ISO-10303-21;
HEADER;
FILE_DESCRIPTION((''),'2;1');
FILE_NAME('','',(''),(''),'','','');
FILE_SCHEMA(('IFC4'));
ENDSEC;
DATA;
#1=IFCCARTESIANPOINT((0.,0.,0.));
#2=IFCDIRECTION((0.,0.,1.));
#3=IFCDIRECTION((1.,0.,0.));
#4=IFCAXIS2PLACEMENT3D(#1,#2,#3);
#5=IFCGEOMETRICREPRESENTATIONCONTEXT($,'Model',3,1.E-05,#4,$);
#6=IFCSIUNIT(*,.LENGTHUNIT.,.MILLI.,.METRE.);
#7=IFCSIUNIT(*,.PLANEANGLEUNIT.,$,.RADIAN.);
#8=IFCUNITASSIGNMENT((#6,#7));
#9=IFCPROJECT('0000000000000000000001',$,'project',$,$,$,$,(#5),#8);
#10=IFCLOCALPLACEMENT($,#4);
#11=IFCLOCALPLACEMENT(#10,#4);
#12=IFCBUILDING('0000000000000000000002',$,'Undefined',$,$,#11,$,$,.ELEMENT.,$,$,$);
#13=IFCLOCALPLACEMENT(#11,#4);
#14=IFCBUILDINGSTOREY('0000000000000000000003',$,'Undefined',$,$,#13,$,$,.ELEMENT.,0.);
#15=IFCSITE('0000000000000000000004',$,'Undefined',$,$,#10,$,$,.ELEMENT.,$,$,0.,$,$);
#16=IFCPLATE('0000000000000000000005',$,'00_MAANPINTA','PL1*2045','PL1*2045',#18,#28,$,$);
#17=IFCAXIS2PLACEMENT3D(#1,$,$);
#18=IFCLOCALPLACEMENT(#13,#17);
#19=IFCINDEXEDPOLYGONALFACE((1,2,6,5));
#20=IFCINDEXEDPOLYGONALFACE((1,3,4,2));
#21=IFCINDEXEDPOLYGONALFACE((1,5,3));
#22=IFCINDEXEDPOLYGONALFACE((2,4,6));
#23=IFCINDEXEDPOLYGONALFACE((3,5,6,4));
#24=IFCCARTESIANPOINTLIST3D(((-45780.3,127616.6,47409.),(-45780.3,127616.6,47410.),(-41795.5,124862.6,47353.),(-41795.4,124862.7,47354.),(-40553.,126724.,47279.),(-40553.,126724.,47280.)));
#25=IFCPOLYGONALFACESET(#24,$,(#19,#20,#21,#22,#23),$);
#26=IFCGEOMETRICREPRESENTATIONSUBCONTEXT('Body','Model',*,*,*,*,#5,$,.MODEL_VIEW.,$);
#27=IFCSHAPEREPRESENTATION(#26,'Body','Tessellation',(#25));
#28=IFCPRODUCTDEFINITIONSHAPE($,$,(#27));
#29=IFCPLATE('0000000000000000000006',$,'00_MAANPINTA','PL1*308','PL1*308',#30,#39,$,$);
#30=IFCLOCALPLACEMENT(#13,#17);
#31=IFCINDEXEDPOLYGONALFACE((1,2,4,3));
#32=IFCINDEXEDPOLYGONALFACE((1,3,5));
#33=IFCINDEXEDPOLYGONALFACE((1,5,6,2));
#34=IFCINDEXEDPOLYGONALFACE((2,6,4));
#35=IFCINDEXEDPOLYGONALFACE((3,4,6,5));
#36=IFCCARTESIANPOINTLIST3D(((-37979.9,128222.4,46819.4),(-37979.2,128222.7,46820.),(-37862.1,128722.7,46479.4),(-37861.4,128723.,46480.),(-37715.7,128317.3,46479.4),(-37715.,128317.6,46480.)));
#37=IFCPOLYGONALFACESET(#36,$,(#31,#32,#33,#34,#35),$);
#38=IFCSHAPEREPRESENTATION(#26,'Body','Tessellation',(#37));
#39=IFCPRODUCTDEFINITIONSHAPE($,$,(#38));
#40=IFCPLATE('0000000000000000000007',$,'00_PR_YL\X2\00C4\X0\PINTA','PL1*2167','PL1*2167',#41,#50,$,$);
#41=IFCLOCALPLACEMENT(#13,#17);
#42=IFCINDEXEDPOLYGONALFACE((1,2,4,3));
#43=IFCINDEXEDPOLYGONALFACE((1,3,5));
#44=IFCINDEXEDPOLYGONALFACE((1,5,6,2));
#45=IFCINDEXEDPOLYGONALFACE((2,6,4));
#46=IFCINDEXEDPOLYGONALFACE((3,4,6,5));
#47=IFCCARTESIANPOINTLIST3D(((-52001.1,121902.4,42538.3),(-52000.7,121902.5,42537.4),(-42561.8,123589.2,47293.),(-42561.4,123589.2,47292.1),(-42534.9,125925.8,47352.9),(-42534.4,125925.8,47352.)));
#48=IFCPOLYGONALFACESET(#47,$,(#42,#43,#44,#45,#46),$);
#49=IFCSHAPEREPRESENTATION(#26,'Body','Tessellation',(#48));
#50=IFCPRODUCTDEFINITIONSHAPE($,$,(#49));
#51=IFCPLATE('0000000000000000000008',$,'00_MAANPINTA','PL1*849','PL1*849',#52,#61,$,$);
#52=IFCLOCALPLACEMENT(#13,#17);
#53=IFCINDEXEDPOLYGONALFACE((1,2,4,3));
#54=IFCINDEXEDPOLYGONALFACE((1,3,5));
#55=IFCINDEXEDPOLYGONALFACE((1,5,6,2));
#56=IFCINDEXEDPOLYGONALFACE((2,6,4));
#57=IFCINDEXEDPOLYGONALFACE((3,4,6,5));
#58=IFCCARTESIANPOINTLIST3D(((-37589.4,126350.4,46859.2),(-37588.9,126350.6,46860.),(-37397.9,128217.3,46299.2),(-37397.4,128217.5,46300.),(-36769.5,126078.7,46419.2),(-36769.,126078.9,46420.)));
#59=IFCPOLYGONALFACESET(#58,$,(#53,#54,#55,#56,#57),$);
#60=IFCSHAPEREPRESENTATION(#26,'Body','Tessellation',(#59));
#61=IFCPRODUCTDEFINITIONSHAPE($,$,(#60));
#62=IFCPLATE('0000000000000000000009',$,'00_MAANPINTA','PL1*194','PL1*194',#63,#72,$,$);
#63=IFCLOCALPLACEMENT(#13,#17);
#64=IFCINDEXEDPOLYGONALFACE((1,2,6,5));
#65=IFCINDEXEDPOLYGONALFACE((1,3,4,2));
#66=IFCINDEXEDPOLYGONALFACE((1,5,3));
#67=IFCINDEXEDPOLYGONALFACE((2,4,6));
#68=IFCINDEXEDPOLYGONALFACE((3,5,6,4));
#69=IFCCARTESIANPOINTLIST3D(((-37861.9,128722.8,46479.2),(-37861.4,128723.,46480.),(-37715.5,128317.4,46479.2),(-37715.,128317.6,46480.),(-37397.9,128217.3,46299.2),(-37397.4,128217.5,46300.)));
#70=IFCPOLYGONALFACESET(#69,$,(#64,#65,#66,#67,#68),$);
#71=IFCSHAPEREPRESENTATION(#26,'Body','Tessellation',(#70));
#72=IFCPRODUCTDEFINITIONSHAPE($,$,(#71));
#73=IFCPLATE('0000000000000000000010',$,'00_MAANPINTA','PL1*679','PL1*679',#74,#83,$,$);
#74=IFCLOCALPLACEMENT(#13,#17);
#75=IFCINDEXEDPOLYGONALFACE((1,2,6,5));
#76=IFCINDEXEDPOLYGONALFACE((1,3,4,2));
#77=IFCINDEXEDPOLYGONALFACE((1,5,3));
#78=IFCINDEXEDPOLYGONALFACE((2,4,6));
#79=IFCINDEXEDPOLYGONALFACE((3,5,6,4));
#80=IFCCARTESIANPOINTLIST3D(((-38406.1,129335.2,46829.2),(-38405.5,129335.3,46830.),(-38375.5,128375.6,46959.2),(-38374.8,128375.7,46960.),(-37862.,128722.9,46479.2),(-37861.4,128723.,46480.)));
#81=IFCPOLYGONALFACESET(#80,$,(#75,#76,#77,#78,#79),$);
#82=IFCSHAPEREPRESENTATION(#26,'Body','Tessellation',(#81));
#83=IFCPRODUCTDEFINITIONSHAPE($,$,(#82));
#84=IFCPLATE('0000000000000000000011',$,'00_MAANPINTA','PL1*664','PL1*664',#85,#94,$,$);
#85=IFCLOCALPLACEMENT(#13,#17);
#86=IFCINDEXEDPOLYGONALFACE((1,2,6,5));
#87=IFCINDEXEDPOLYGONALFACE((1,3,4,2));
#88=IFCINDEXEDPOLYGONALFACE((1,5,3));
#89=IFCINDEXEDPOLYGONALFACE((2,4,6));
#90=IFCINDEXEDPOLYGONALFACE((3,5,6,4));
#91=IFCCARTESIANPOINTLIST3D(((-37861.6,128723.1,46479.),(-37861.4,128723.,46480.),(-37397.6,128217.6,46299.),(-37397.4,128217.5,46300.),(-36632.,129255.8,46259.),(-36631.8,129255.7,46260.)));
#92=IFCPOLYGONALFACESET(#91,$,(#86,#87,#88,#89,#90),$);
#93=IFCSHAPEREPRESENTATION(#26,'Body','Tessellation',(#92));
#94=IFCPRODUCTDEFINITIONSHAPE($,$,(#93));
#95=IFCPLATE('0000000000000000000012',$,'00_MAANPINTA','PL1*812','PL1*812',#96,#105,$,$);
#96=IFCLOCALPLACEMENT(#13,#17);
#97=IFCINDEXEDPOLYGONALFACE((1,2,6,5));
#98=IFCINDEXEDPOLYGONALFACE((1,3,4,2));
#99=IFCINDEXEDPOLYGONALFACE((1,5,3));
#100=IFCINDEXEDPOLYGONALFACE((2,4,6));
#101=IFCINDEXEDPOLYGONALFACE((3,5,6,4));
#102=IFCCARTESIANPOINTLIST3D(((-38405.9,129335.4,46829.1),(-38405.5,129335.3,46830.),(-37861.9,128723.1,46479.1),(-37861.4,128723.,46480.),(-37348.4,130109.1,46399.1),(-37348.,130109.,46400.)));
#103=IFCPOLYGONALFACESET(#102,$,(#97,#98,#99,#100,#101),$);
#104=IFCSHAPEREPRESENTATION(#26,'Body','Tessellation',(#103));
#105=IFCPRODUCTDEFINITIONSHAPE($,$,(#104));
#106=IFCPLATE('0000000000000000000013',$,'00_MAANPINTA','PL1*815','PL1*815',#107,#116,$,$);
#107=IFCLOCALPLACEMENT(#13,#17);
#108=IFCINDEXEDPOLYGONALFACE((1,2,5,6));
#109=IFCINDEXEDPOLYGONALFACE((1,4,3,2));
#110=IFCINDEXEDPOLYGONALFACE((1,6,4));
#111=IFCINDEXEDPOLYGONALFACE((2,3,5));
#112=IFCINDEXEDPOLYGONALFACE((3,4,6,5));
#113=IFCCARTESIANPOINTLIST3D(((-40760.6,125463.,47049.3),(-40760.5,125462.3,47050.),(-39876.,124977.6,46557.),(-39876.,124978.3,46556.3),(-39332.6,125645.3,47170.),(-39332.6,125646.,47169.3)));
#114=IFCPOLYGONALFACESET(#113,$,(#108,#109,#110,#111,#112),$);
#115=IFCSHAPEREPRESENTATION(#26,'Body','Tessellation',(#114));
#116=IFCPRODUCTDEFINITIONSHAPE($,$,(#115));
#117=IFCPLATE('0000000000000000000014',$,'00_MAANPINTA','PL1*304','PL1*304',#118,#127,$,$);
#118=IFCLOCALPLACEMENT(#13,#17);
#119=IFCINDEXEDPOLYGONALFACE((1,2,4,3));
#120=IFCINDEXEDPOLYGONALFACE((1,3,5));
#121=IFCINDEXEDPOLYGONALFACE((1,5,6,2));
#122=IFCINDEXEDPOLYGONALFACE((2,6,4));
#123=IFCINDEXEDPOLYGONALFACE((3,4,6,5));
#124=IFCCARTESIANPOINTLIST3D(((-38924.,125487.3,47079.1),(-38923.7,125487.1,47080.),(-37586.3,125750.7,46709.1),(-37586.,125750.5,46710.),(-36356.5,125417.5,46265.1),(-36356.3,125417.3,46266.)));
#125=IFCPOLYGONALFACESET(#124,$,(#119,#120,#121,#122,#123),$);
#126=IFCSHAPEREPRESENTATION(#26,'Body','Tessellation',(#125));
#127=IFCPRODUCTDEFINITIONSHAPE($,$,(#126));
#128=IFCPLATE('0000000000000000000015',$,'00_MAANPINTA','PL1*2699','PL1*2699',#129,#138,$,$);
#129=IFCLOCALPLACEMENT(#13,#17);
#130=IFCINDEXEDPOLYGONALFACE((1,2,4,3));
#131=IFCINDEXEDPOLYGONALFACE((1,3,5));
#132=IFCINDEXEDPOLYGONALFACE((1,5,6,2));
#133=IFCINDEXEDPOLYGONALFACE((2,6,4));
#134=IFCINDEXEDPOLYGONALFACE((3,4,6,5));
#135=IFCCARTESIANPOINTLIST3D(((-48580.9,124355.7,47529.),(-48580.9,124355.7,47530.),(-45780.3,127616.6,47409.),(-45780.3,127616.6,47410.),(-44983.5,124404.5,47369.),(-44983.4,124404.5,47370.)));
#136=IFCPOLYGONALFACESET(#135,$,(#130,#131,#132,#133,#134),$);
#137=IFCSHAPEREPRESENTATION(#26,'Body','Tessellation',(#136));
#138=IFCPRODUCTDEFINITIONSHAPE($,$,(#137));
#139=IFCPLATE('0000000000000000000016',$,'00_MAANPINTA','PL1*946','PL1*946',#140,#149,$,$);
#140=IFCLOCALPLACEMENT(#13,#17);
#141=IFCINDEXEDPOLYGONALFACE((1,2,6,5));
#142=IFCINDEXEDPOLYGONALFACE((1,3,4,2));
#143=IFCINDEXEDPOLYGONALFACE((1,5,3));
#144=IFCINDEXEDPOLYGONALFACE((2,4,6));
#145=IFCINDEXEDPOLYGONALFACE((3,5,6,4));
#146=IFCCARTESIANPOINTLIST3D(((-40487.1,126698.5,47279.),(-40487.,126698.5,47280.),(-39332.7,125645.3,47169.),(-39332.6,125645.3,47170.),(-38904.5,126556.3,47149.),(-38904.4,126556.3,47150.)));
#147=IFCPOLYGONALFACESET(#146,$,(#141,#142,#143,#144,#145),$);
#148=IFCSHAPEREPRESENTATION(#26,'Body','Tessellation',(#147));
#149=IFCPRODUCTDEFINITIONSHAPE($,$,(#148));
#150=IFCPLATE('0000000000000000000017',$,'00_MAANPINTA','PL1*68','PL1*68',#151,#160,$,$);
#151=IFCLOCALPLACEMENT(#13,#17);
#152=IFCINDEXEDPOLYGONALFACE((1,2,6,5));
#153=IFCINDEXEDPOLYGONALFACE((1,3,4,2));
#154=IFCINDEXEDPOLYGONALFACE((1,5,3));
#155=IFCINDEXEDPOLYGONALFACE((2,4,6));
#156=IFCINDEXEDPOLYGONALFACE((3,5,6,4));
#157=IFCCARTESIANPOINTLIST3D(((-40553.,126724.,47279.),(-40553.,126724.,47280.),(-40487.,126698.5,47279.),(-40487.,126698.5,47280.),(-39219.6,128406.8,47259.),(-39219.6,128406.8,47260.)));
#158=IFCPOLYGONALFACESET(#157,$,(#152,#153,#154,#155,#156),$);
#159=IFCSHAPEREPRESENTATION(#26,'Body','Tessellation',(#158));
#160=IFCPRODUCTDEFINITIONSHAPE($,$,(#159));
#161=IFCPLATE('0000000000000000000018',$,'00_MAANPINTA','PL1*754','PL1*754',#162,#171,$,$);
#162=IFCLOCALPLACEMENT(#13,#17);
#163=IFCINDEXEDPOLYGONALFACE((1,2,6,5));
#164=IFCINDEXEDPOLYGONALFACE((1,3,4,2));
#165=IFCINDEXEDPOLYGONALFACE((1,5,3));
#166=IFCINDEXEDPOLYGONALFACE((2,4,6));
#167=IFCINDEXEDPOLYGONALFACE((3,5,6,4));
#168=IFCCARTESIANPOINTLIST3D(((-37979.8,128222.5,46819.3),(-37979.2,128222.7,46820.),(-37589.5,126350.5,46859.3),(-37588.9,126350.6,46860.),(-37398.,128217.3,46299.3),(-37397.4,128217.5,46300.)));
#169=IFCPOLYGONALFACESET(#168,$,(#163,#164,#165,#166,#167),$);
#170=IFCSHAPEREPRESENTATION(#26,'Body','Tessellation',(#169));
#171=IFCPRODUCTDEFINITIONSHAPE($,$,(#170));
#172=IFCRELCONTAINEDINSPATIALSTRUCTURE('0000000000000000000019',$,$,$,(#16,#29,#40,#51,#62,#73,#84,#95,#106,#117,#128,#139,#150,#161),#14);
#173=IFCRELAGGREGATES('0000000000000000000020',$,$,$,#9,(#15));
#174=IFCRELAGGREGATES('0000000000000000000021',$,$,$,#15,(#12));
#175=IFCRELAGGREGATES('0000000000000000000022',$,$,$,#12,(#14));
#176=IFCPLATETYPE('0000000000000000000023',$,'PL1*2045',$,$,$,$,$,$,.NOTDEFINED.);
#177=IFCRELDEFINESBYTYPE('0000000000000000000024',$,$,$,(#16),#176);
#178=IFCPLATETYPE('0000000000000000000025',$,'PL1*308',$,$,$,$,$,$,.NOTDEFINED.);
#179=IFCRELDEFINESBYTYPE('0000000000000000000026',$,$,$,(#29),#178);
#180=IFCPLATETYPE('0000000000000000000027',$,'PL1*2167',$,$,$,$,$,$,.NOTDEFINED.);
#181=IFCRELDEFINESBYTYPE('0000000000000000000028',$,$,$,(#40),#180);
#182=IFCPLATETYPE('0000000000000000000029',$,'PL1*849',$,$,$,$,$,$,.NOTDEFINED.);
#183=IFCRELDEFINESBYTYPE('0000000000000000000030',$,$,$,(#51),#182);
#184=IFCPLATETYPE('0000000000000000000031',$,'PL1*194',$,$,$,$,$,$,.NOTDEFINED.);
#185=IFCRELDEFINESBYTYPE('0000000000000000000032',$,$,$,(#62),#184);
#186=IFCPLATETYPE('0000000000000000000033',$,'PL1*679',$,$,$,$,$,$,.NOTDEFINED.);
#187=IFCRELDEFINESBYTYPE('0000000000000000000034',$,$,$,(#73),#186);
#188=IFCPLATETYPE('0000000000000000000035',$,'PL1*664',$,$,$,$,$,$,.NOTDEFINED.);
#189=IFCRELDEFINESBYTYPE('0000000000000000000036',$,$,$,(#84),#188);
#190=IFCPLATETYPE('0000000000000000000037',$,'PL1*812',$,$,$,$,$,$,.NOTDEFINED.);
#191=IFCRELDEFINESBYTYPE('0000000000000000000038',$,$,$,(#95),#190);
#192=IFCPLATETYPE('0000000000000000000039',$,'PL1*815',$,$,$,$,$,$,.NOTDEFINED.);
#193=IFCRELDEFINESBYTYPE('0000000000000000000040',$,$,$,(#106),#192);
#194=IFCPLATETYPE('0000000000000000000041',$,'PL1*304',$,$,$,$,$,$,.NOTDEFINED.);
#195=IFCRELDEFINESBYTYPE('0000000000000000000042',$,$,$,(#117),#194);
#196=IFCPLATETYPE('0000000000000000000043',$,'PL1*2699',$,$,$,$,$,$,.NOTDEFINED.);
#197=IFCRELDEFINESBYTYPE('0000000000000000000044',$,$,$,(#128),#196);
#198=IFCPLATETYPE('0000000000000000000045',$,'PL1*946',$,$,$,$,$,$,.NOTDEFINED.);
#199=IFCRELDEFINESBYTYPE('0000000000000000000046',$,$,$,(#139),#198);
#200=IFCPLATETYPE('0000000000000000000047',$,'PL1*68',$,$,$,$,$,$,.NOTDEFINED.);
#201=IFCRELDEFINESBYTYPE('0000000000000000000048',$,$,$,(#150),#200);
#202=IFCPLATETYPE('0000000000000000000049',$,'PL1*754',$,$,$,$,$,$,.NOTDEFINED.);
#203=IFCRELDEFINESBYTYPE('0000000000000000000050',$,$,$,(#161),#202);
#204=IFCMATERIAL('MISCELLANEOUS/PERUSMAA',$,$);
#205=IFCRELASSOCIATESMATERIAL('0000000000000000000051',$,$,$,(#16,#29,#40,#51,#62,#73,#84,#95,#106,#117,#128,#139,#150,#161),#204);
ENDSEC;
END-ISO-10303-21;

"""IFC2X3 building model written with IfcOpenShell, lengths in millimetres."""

from ifc_helpers import new_model, si_unit, frame, origin_with_axes, place, context, subcontext, project, spatial, polyline, outline, extrude, material, type_object, element, save


model = new_model("IFC2X3")

# Units and contexts
model_context = context("Model", 3, precision=1e-05, world=origin_with_axes())
body_context = subcontext(model_context, "Body", "Model", "MODEL_VIEW")
ifc_project = project(units=[si_unit("LENGTHUNIT", "METRE", prefix="MILLI"), si_unit("PLANEANGLEUNIT", "RADIAN")], contexts=[model_context])

# Site, building, storey
site_placement = place(None, origin_with_axes())
site = spatial("IfcSite", under=ifc_project, at=site_placement, Name="Undefined", CompositionType="ELEMENT", RefElevation=0.0)
building_placement = place(site_placement, origin_with_axes())
building = spatial("IfcBuilding", under=site, at=building_placement, Name="Undefined", CompositionType="ELEMENT")
storey_placement = place(building_placement, origin_with_axes())
storey = spatial("IfcBuildingStorey", under=building, at=storey_placement, Name="Undefined", CompositionType="ELEMENT", Elevation=0.0)

# Plates
ifc_material = material(Name="MISCELLANEOUS/PERUSMAA")
plate_type_1 = type_object("IfcPlateType", Name="PL1*2045", PredefinedType="NOTDEFINED")
plate_1_placement = place(storey_placement, frame((-45780.3, 127616.6, 47409.5), z_axis=(-0.028401, -0.020773, -0.999381), x_axis=(0.985436, -0.168271, -0.024507)))
element("IfcPlate", 1, at=plate_1_placement, inside=storey, type_object=plate_type_1, material=ifc_material, Name="00_MAANPINTA", Description="PL1*2045", ObjectType="PL1*2045", context=body_context, shape_type="SweptSolid", body=[
    extrude(outline(polyline([(0.0, 0.0), (5304.5, 0.0), (4391.6, 2044.6), (0.0, 0.0)])), frame((0.0, 0.0, -0.5), z_axis=(0.0, 0.0, 1.0), x_axis=(1.0, 0.0, 0.0)), (0.0, 0.0, 1.0), 1.0),
])
plate_type_2 = type_object("IfcPlateType", Name="PL1*308", PredefinedType="NOTDEFINED")
plate_2_placement = place(storey_placement, frame((-37861.8, 128722.9, 46479.7), z_axis=(-0.725277, -0.261961, -0.63667), x_axis=(0.339708, -0.940531, 0.0)))
element("IfcPlate", 2, at=plate_2_placement, inside=storey, type_object=plate_type_2, material=ifc_material, Name="00_MAANPINTA", Description="PL1*308", ObjectType="PL1*308", context=body_context, shape_type="SweptSolid", body=[
    extrude(outline(polyline([(0.0, 0.0), (431.0, 0.0), (430.6, 440.9), (0.0, 0.0)])), frame((0.0, 0.0, -0.5), z_axis=(0.0, 0.0, 1.0), x_axis=(1.0, 0.0, 0.0)), (0.0, 0.0, 1.0), 1.0),
])
plate_type_3 = type_object("IfcPlateType", Name="PL1*2167", PredefinedType="NOTDEFINED")
plate_3_placement = place(storey_placement, frame((-42534.6, 125925.8, 47352.5), z_axis=(0.447263, 0.017763, -0.894226), x_axis=(-0.011536, -0.999605, -0.025626)))
element("IfcPlate", 3, at=plate_3_placement, inside=storey, type_object=plate_type_3, material=ifc_material, Name="00_PR_YLÄPINTA", Description="PL1*2167", ObjectType="PL1*2167", context=body_context, shape_type="SweptSolid", body=[
    extrude(outline(polyline([(0.0, 0.0), (2337.6, 0.0), (4254.4, 10529.9), (0.0, 0.0)])), frame((0.0, 0.0, -0.5), z_axis=(0.0, 0.0, 1.0), x_axis=(1.0, 0.0, 0.0)), (0.0, 0.0, 1.0), 1.0),
])
plate_type_4 = type_object("IfcPlateType", Name="PL1*849", PredefinedType="NOTDEFINED")
plate_4_placement = place(storey_placement, frame((-37589.1, 126350.5, 46859.6), z_axis=(-0.513614, -0.197764, -0.834919), x_axis=(0.097785, 0.953244, -0.285945)))
element("IfcPlate", 4, at=plate_4_placement, inside=storey, type_object=plate_type_4, material=ifc_material, Name="00_MAANPINTA", Description="PL1*849", ObjectType="PL1*849", context=body_context, shape_type="SweptSolid", body=[
    extrude(outline(polyline([(0.0, 0.0), (1958.4, 0.0), (-53.0, 967.9), (0.0, 0.0)])), frame((0.0, 0.0, -0.5), z_axis=(0.0, 0.0, 1.0), x_axis=(1.0, 0.0, 0.0)), (0.0, 0.0, 1.0), 1.0),
])
plate_type_5 = type_object("IfcPlateType", Name="PL1*194", PredefinedType="NOTDEFINED")
plate_5_placement = place(storey_placement, frame((-37397.6, 128217.4, 46299.6), z_axis=(-0.528871, -0.191021, -0.826926), x_axis=(-0.839011, 0.264503, 0.475499)))
element("IfcPlate", 5, at=plate_5_placement, inside=storey, type_object=plate_type_5, material=ifc_material, Name="00_MAANPINTA", Description="PL1*194", ObjectType="PL1*194", context=body_context, shape_type="SweptSolid", body=[
    extrude(outline(polyline([(0.0, 0.0), (378.5, 0.0), (608.6, 364.5), (0.0, 0.0)])), frame((0.0, 0.0, -0.5), z_axis=(0.0, 0.0, 1.0), x_axis=(1.0, 0.0, 0.0)), (0.0, 0.0, 1.0), 1.0),
])
plate_type_6 = type_object("IfcPlateType", Name="PL1*679", PredefinedType="NOTDEFINED")
plate_6_placement = place(storey_placement, frame((-38405.8, 129335.2, 46829.6), z_axis=(-0.631689, -0.123826, -0.765269), x_axis=(0.61078, -0.687422, -0.392936)))
element("IfcPlate", 6, at=plate_6_placement, inside=storey, type_object=plate_type_6, material=ifc_material, Name="00_MAANPINTA", Description="PL1*679", ObjectType="PL1*679", context=body_context, shape_type="SweptSolid", body=[
    extrude(outline(polyline([(0.0, 0.0), (890.7, 0.0), (627.2, 738.4), (0.0, 0.0)])), frame((0.0, 0.0, -0.5), z_axis=(0.0, 0.0, 1.0), x_axis=(1.0, 0.0, 0.0)), (0.0, 0.0, 1.0), 1.0),
])
plate_type_7 = type_object("IfcPlateType", Name="PL1*664", PredefinedType="NOTDEFINED")
plate_7_placement = place(storey_placement, frame((-37397.5, 128217.5, 46299.5), z_axis=(-0.229838, 0.132335, -0.96419), x_axis=(-0.654092, 0.712593, 0.253723)))
element("IfcPlate", 7, at=plate_7_placement, inside=storey, type_object=plate_type_7, material=ifc_material, Name="00_MAANPINTA", Description="PL1*664", ObjectType="PL1*664", context=body_context, shape_type="SweptSolid", body=[
    extrude(outline(polyline([(0.0, 0.0), (709.4, 0.0), (228.9, 1270.1), (0.0, 0.0)])), frame((0.0, 0.0, -0.5), z_axis=(0.0, 0.0, 1.0), x_axis=(1.0, 0.0, 0.0)), (0.0, 0.0, 1.0), 1.0),
])
plate_type_8 = type_object("IfcPlateType", Name="PL1*812", PredefinedType="NOTDEFINED")
plate_8_placement = place(storey_placement, frame((-37861.6, 128723.1, 46479.6), z_axis=(-0.444248, 0.113278, -0.888713), x_axis=(-0.61078, 0.687422, 0.392936)))
element("IfcPlate", 8, at=plate_8_placement, inside=storey, type_object=plate_type_8, material=ifc_material, Name="00_MAANPINTA", Description="PL1*812", ObjectType="PL1*812", context=body_context, shape_type="SweptSolid", body=[
    extrude(outline(polyline([(0.0, 0.0), (890.7, 0.0), (607.7, 1349.7), (0.0, 0.0)])), frame((0.0, 0.0, -0.5), z_axis=(0.0, 0.0, 1.0), x_axis=(1.0, 0.0, 0.0)), (0.0, 0.0, 1.0), 1.0),
])
plate_type_9 = type_object("IfcPlateType", Name="PL1*815", PredefinedType="NOTDEFINED")
plate_9_placement = place(storey_placement, frame((-39332.6, 125645.7, 47169.6), z_axis=(-0.027219, 0.687945, -0.725252), x_axis=(-0.514173, -0.631822, -0.580024)))
element("IfcPlate", 9, at=plate_9_placement, inside=storey, type_object=plate_type_9, material=ifc_material, Name="00_MAANPINTA", Description="PL1*815", ObjectType="PL1*815", context=body_context, shape_type="SweptSolid", body=[
    extrude(outline(polyline([(0.0, 0.0), (1056.9, 0.0), (919.4, 1114.2), (0.0, 0.0)])), frame((0.0, 0.0, -0.5), z_axis=(0.0, 0.0, 1.0), x_axis=(1.0, 0.0, 0.0)), (0.0, 0.0, 1.0), 1.0),
])
plate_type_10 = type_object("IfcPlateType", Name="PL1*304", PredefinedType="NOTDEFINED")
plate_10_placement = place(storey_placement, frame((-38923.9, 125487.2, 47079.5), z_axis=(-0.293628, 0.169827, -0.940713), x_axis=(0.946913, 0.186444, -0.261905)))
element("IfcPlate", 10, at=plate_10_placement, inside=storey, type_object=plate_type_10, material=ifc_material, Name="00_MAANPINTA", Description="PL1*304", ObjectType="PL1*304", context=body_context, shape_type="SweptSolid", body=[
    extrude(outline(polyline([(0.0, 0.0), (1412.7, 0.0), (2631.3, 579.1), (0.0, 0.0)])), frame((0.0, 0.0, -0.5), z_axis=(0.0, 0.0, 1.0), x_axis=(1.0, 0.0, 0.0)), (0.0, 0.0, 1.0), 1.0),
])
plate_type_11 = type_object("IfcPlateType", Name="PL1*2699", PredefinedType="NOTDEFINED")
plate_11_placement = place(storey_placement, frame((-45780.3, 127616.6, 47409.5), z_axis=(-0.044451, 0.001414, -0.999011), x_axis=(0.240757, -0.97051, -0.012086)))
element("IfcPlate", 11, at=plate_11_placement, inside=storey, type_object=plate_type_11, material=ifc_material, Name="00_MAANPINTA", Description="PL1*2699", ObjectType="PL1*2699", context=body_context, shape_type="SweptSolid", body=[
    extrude(outline(polyline([(0.0, 0.0), (3309.7, 0.0), (2489.0, 3506.6), (0.0, 0.0)])), frame((0.0, 0.0, -0.5), z_axis=(0.0, 0.0, 1.0), x_axis=(1.0, 0.0, 0.0)), (0.0, 0.0, 1.0), 1.0),
])
plate_type_12 = type_object("IfcPlateType", Name="PL1*946", PredefinedType="NOTDEFINED")
plate_12_placement = place(storey_placement, frame((-40487.1, 126698.5, 47279.5), z_axis=(-0.080433, 0.01593, -0.996633), x_axis=(0.992671, -0.089197, -0.081539)))
element("IfcPlate", 12, at=plate_12_placement, inside=storey, type_object=plate_type_12, material=ifc_material, Name="00_MAANPINTA", Description="PL1*946", ObjectType="PL1*946", context=body_context, shape_type="SweptSolid", body=[
    extrude(outline(polyline([(0.0, 0.0), (1594.3, 0.0), (1248.9, 945.6), (0.0, 0.0)])), frame((0.0, 0.0, -0.5), z_axis=(0.0, 0.0, 1.0), x_axis=(1.0, 0.0, 0.0)), (0.0, 0.0, 1.0), 1.0),
])
plate_type_13 = type_object("IfcPlateType", Name="PL1*68", PredefinedType="NOTDEFINED")
plate_13_placement = place(storey_placement, frame((-40487.0, 126698.5, 47279.5), z_axis=(-0.003519, -0.009096, -0.999952), x_axis=(-0.932639, 0.360811, 0.0)))
element("IfcPlate", 13, at=plate_13_placement, inside=storey, type_object=plate_type_13, material=ifc_material, Name="00_MAANPINTA", Description="PL1*68", ObjectType="PL1*68", context=body_context, shape_type="SweptSolid", body=[
    extrude(outline(polyline([(0.0, 0.0), (70.7, 0.0), (-565.7, 2050.7), (0.0, 0.0)])), frame((0.0, 0.0, -0.5), z_axis=(0.0, 0.0, 1.0), x_axis=(1.0, 0.0, 0.0)), (0.0, 0.0, 1.0), 1.0),
])
plate_type_14 = type_object("IfcPlateType", Name="PL1*754", PredefinedType="NOTDEFINED")
plate_14_placement = place(storey_placement, frame((-37979.5, 128222.6, 46819.6), z_axis=(-0.659304, -0.153178, -0.736107), x_axis=(0.745571, -0.006669, -0.666393)))
element("IfcPlate", 14, at=plate_14_placement, inside=storey, type_object=plate_type_14, material=ifc_material, Name="00_MAANPINTA", Description="PL1*754", ObjectType="PL1*754", context=body_context, shape_type="SweptSolid", body=[
    extrude(outline(polyline([(0.0, 0.0), (780.3, 0.0), (276.8, 1892.6), (0.0, 0.0)])), frame((0.0, 0.0, -0.5), z_axis=(0.0, 0.0, 1.0), x_axis=(1.0, 0.0, 0.0)), (0.0, 0.0, 1.0), 1.0),
])

save(model, "model.ifc")
